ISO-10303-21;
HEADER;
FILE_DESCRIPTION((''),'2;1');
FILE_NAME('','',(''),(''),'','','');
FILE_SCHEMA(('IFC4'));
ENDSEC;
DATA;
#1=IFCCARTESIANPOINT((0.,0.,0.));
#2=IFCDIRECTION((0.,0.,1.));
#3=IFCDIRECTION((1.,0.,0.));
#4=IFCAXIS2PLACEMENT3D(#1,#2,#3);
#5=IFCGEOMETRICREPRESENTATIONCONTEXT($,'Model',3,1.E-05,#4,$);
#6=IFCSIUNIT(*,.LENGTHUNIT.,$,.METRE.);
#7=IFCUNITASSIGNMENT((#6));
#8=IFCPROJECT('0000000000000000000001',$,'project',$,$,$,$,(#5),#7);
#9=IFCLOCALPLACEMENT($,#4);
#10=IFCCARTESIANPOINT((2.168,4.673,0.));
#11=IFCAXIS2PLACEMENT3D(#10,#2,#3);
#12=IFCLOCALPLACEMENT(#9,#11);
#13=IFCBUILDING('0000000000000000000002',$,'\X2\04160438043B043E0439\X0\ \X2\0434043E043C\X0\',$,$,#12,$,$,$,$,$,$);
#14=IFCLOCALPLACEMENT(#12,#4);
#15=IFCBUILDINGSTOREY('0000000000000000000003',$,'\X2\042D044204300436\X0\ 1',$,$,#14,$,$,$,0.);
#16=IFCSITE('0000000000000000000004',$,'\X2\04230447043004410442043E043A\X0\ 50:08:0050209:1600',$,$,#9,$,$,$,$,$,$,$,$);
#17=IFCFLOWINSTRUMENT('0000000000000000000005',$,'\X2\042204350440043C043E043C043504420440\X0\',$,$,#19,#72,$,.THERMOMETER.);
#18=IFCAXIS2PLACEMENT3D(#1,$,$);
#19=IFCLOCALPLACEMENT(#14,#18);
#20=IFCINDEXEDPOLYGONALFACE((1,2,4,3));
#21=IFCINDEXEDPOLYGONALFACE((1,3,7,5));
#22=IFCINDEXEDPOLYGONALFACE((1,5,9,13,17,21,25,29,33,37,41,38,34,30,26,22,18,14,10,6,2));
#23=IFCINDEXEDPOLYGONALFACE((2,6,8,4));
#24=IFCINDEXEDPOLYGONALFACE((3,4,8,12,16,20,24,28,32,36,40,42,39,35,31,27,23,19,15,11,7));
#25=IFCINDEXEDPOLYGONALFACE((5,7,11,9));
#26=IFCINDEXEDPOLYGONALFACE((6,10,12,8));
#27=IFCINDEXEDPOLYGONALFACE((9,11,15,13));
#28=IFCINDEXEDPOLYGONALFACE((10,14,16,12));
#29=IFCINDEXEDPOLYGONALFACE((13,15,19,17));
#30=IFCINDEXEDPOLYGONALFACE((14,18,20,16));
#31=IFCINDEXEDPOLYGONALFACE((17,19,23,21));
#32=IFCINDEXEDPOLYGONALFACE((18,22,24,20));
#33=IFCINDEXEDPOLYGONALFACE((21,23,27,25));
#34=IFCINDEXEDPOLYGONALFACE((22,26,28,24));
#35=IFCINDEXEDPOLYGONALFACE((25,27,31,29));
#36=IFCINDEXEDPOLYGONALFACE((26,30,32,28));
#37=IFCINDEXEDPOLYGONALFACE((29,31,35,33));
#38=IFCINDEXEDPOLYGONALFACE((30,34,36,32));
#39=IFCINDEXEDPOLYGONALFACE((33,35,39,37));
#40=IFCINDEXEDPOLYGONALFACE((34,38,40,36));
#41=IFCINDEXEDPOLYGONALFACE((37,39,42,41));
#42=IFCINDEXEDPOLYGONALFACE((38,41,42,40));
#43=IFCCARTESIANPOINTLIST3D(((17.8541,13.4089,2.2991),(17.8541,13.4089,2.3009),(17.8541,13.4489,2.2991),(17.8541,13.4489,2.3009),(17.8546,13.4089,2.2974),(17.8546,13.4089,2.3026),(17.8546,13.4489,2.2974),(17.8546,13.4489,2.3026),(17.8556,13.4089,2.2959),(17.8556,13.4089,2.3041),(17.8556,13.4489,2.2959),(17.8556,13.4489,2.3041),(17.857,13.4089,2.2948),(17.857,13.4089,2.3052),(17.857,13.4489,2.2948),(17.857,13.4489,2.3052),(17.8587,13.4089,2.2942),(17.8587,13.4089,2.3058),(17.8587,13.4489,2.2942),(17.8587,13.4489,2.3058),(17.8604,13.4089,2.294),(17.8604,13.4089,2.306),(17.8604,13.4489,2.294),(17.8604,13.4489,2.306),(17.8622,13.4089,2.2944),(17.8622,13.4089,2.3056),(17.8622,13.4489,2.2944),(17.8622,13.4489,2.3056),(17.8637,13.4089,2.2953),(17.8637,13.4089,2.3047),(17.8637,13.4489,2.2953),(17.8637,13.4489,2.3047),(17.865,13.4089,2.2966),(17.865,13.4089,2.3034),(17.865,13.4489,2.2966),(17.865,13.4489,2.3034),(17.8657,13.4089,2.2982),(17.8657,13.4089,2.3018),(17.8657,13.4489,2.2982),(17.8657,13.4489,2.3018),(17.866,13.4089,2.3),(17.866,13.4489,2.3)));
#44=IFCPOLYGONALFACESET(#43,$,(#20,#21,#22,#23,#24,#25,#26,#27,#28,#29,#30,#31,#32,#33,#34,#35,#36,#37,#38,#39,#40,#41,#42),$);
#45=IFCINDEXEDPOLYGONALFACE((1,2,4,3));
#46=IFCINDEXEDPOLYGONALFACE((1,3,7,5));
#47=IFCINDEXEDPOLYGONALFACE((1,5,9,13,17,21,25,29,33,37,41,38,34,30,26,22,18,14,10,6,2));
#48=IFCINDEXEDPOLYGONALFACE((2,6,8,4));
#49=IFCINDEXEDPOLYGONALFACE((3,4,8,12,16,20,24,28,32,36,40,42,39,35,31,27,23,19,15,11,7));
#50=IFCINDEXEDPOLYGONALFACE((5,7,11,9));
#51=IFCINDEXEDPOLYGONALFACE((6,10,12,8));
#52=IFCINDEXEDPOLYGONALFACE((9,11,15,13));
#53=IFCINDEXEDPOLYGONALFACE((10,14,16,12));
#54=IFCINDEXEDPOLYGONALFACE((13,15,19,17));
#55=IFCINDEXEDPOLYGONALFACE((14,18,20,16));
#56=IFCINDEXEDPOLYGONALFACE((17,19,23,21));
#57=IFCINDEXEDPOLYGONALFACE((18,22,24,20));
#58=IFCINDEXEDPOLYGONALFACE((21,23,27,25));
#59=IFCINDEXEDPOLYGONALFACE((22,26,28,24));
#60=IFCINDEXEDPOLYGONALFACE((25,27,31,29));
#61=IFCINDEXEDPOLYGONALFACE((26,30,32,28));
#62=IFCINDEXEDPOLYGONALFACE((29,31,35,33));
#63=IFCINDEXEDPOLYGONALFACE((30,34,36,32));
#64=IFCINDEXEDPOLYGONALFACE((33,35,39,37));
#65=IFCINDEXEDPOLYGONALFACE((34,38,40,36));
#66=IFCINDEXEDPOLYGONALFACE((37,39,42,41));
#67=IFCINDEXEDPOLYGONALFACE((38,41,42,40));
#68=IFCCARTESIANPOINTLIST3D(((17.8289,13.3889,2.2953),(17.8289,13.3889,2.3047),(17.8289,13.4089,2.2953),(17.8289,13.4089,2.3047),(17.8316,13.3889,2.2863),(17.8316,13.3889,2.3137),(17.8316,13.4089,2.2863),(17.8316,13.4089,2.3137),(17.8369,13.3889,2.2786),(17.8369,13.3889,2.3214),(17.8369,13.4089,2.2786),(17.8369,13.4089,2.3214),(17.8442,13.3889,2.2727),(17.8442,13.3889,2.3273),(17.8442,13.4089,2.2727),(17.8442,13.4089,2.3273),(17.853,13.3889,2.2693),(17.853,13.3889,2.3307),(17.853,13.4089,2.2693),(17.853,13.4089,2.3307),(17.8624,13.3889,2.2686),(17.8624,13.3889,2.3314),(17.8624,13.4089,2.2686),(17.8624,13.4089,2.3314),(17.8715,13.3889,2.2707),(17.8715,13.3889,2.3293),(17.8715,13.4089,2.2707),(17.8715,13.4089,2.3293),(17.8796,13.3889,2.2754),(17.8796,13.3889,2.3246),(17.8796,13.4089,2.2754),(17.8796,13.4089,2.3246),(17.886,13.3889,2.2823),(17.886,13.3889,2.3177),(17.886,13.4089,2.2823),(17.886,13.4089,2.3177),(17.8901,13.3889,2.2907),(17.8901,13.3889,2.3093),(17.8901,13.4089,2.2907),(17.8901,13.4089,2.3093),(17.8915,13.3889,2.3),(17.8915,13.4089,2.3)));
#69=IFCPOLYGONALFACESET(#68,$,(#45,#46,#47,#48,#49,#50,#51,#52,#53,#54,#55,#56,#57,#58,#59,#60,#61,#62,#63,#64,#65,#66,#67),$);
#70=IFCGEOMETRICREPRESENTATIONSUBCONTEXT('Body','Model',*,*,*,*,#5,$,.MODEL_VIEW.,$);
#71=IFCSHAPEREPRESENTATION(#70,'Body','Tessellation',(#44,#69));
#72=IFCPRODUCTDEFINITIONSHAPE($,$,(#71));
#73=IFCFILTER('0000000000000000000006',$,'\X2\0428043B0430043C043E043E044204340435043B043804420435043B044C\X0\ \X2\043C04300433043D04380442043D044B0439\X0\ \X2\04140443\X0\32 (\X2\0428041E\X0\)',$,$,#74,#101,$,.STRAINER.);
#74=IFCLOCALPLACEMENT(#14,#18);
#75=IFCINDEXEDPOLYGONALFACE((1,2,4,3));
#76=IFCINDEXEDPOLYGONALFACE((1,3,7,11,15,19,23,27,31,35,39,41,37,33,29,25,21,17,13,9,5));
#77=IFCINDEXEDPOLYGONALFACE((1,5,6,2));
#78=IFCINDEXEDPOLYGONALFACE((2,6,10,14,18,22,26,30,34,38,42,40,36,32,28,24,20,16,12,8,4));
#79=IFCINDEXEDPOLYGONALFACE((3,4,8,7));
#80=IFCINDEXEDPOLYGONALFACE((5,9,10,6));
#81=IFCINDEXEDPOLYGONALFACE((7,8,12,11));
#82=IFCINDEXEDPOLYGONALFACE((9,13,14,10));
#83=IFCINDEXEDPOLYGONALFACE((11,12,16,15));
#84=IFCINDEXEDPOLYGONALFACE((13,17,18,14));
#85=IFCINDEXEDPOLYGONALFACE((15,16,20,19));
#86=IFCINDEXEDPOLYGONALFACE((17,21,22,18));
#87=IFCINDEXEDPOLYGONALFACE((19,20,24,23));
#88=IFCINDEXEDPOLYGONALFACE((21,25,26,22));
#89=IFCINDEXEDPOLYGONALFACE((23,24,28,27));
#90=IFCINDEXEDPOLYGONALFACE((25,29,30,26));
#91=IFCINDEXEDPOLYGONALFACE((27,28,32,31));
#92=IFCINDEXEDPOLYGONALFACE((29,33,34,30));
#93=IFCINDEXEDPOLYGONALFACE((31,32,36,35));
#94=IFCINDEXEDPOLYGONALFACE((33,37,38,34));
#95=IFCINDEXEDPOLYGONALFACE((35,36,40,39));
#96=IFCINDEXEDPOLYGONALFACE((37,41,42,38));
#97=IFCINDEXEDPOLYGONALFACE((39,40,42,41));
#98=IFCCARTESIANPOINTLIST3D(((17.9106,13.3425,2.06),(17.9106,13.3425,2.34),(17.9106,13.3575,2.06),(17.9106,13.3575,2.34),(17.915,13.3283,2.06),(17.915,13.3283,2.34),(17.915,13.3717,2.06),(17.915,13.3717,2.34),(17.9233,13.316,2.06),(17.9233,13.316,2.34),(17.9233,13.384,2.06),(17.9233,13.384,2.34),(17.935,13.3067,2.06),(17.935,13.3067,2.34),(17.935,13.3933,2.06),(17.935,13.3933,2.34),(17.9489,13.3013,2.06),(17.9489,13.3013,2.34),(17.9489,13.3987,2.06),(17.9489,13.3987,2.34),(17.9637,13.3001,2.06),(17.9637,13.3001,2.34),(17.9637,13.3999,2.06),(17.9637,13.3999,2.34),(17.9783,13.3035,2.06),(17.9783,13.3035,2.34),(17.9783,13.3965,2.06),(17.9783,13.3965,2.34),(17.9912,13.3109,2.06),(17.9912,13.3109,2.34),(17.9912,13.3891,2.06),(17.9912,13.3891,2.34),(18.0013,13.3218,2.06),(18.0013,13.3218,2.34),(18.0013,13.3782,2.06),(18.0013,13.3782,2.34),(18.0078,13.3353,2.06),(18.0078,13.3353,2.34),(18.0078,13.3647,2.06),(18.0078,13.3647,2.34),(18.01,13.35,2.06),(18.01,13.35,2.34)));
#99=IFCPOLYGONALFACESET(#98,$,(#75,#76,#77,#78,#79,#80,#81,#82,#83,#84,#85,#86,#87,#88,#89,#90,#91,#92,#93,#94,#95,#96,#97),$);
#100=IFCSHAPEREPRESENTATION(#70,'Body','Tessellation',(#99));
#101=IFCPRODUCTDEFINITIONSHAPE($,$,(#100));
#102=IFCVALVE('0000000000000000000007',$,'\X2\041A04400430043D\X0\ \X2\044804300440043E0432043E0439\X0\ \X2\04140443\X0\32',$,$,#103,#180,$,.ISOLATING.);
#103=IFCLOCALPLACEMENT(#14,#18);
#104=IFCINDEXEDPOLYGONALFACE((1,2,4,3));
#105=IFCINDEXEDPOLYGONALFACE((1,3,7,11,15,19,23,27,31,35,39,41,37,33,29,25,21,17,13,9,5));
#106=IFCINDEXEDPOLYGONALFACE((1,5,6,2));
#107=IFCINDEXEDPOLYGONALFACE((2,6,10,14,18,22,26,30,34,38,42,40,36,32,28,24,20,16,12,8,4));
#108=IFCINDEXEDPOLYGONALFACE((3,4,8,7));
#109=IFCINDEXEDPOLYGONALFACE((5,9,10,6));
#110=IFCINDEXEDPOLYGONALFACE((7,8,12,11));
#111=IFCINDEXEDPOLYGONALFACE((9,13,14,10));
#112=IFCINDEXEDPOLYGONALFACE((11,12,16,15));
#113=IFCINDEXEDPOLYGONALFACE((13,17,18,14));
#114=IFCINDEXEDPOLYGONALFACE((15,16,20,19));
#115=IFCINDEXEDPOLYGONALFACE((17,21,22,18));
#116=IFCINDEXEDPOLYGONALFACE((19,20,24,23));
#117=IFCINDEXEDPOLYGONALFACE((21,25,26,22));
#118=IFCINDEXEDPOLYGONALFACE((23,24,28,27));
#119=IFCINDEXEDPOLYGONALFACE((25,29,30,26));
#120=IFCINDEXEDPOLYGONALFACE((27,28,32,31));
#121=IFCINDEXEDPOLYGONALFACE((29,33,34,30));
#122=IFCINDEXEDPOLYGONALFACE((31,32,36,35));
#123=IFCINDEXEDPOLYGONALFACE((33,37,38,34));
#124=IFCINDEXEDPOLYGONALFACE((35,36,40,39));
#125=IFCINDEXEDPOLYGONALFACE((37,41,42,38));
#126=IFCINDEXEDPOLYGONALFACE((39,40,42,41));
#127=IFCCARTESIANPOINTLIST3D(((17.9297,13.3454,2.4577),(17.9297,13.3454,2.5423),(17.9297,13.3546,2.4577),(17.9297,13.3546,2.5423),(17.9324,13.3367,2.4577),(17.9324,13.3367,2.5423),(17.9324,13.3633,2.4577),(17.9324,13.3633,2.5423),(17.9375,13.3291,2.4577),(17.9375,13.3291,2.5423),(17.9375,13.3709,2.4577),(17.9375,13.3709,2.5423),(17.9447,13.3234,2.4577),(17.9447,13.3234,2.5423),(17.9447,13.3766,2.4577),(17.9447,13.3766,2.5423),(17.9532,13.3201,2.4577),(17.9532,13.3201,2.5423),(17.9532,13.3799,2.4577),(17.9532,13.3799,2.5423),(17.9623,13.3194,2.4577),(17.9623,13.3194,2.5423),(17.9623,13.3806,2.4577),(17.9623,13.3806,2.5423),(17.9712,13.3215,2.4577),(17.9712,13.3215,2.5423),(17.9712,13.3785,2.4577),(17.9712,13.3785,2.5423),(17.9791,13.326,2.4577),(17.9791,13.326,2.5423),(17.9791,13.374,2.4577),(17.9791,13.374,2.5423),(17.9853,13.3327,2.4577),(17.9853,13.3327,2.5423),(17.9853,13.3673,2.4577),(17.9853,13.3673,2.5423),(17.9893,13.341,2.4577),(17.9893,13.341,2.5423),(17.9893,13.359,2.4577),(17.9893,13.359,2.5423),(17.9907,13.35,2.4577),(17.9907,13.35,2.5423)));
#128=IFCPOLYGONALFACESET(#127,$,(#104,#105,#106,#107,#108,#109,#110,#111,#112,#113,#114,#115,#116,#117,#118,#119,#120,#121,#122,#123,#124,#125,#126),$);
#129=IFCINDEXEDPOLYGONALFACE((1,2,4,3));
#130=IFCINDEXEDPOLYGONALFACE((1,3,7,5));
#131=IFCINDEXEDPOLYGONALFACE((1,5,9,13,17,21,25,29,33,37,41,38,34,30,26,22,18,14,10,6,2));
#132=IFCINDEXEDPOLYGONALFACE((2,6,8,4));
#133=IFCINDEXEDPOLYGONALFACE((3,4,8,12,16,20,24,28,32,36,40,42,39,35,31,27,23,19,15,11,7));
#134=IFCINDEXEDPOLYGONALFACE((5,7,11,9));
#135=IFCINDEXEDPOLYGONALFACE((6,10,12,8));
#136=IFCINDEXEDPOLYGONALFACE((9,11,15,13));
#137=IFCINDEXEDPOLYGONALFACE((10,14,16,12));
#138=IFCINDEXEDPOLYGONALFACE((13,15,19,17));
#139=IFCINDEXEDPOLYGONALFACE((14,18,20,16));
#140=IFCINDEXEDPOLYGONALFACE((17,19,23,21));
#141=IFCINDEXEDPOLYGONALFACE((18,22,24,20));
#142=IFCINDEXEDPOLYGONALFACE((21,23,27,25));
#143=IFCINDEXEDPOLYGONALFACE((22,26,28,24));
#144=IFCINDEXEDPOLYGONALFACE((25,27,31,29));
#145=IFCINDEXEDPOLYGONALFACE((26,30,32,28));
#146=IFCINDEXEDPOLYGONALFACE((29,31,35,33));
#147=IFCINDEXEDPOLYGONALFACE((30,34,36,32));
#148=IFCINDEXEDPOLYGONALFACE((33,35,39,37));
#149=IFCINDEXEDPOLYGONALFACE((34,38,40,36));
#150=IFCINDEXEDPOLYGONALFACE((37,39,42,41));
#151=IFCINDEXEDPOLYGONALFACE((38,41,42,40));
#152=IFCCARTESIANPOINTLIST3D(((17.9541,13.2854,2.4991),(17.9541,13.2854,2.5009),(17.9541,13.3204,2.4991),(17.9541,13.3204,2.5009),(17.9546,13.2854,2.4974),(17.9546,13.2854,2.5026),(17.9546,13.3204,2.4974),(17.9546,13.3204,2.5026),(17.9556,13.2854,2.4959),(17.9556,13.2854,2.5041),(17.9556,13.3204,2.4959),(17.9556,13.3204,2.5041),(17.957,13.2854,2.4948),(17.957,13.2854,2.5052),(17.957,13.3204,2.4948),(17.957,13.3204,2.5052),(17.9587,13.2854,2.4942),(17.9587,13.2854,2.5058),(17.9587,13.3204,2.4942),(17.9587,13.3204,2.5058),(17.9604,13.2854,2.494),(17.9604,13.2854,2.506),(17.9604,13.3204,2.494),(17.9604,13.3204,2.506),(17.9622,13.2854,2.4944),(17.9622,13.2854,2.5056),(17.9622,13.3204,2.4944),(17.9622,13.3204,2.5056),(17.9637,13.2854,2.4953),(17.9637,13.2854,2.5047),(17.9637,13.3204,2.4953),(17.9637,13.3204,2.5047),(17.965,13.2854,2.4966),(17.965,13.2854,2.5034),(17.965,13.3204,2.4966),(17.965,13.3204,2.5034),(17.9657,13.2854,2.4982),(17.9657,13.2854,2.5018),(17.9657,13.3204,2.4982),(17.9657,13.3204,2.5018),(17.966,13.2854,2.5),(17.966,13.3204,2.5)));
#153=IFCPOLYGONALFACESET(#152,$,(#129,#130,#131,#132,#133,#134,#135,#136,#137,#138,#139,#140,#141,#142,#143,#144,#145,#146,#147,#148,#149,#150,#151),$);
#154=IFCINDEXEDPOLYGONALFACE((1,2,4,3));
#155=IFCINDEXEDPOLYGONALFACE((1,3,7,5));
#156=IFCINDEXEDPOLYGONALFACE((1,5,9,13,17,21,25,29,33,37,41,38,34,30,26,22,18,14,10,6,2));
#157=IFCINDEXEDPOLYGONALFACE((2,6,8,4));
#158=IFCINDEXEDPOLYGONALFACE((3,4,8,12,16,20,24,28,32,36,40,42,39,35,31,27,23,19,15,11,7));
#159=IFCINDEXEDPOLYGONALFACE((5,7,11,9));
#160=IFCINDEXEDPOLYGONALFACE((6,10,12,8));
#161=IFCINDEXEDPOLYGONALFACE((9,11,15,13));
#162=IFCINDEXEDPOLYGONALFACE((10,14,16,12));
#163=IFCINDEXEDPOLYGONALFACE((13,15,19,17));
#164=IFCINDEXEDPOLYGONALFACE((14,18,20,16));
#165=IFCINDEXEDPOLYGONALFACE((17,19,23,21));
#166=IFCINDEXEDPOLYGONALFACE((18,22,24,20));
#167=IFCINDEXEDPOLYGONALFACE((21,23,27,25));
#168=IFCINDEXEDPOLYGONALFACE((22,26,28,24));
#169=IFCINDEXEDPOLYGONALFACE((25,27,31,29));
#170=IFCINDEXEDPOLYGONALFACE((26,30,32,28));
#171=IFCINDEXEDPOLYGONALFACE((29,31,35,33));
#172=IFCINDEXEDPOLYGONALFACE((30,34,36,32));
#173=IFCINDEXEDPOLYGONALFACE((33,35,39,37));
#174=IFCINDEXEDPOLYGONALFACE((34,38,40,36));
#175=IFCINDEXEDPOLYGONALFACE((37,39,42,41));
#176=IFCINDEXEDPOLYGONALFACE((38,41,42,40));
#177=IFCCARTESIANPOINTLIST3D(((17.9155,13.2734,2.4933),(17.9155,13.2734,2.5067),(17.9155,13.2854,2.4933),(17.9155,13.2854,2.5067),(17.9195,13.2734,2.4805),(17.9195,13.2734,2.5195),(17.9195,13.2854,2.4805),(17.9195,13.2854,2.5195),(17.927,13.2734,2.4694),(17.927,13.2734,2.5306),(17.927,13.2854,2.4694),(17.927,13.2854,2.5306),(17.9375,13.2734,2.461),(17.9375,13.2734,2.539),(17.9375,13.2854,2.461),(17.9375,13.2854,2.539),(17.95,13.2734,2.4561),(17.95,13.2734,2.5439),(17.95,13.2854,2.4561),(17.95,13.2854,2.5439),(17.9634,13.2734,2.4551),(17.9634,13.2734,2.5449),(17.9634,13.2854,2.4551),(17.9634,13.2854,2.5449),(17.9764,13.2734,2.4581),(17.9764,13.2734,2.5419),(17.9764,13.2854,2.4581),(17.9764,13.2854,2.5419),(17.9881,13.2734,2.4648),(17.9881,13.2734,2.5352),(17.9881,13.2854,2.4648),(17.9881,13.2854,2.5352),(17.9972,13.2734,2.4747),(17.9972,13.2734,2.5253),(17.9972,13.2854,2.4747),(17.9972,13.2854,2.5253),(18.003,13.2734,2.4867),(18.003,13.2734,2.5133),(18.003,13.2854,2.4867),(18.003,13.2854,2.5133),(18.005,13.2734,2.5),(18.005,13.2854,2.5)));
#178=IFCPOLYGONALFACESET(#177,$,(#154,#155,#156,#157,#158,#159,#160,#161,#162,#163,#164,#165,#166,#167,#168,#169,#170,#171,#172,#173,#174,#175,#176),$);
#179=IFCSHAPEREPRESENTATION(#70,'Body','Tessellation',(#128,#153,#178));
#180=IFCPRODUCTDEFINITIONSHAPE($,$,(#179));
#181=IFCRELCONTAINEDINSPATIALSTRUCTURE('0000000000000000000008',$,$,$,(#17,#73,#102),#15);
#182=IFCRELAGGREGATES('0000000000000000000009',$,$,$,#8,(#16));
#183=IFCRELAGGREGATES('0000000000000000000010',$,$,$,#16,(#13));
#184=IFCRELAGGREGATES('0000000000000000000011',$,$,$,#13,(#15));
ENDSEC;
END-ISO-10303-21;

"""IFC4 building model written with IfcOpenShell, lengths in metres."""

from ifc_helpers import new_model, si_unit, frame, origin_with_axes, origin_2d, place, context, subcontext, project, spatial, circle, extrude, element, save


model = new_model("IFC4")

# Units and contexts
model_context = context("Model", 3, precision=1e-05, world=origin_with_axes())
body_context = subcontext(model_context, "Body", "Model", "MODEL_VIEW")
ifc_project = project(units=[si_unit("LENGTHUNIT", "METRE")], contexts=[model_context])

# Site, building, storey
site_placement = place(None, origin_with_axes())
site = spatial("IfcSite", under=ifc_project, at=site_placement, Name="Участок 50:08:0050209:1600")
building_placement = place(site_placement, frame((2.168, 4.673, 0.0), z_axis=(0.0, 0.0, 1.0), x_axis=(1.0, 0.0, 0.0)))
building = spatial("IfcBuilding", under=site, at=building_placement, Name="Жилой дом")
storey_placement = place(building_placement, origin_with_axes())
storey = spatial("IfcBuildingStorey", under=building, at=storey_placement, Name="Этаж 1", Elevation=0.0)

# Flow instrument
flow_instrument_1_placement = place(storey_placement, origin_with_axes())
element("IfcFlowInstrument", 1, at=flow_instrument_1_placement, inside=storey, Name="Термометр", PredefinedType="THERMOMETER", context=body_context, shape_type="SweptSolid", body=[
    extrude(circle(Radius=0.006, at=origin_2d()), frame((17.86, 13.4489, 2.3), z_axis=(0.0, -1.0, 0.0), x_axis=(1.0, 0.0, 0.0)), (0.0, 0.0, 1.0), 0.04),
    extrude(circle(Radius=0.0315, at=origin_2d()), frame((17.86, 13.4089, 2.3), z_axis=(0.0, -1.0, 0.0), x_axis=(1.0, 0.0, 0.0)), (0.0, 0.0, 1.0), 0.02),
])

# Filter
ifc_filter_1_placement = place(storey_placement, origin_with_axes())
element("IfcFilter", 2, at=ifc_filter_1_placement, inside=storey, Name="Шламоотделитель магнитный Ду32 (ШО)", PredefinedType="STRAINER", context=body_context, shape_type="SweptSolid", body=[
    extrude(circle(Radius=0.05, at=origin_2d()), frame((17.96, 13.35, 2.06), z_axis=(0.0, 0.0, 1.0), x_axis=(1.0, 0.0, 0.0)), (0.0, 0.0, 1.0), 0.28),
])

# Valve
valve_1_placement = place(storey_placement, origin_with_axes())
element("IfcValve", 3, at=valve_1_placement, inside=storey, Name="Кран шаровой Ду32", PredefinedType="ISOLATING", context=body_context, shape_type="SweptSolid", body=[
    extrude(circle(Radius=0.0307, at=origin_2d()), frame((17.96, 13.35, 2.4577), z_axis=(0.0, 0.0, 1.0), x_axis=(1.0, 0.0, 0.0)), (0.0, 0.0, 1.0), 0.0846),
    extrude(circle(Radius=0.006, at=origin_2d()), frame((17.96, 13.3204, 2.5), z_axis=(0.0, -1.0, 0.0), x_axis=(1.0, 0.0, 0.0)), (0.0, 0.0, 1.0), 0.035),
    extrude(circle(Radius=0.045, at=origin_2d()), frame((17.96, 13.2854, 2.5), z_axis=(0.0, -1.0, 0.0), x_axis=(1.0, 0.0, 0.0)), (0.0, 0.0, 1.0), 0.012),
])

save(model, "model.ifc")
